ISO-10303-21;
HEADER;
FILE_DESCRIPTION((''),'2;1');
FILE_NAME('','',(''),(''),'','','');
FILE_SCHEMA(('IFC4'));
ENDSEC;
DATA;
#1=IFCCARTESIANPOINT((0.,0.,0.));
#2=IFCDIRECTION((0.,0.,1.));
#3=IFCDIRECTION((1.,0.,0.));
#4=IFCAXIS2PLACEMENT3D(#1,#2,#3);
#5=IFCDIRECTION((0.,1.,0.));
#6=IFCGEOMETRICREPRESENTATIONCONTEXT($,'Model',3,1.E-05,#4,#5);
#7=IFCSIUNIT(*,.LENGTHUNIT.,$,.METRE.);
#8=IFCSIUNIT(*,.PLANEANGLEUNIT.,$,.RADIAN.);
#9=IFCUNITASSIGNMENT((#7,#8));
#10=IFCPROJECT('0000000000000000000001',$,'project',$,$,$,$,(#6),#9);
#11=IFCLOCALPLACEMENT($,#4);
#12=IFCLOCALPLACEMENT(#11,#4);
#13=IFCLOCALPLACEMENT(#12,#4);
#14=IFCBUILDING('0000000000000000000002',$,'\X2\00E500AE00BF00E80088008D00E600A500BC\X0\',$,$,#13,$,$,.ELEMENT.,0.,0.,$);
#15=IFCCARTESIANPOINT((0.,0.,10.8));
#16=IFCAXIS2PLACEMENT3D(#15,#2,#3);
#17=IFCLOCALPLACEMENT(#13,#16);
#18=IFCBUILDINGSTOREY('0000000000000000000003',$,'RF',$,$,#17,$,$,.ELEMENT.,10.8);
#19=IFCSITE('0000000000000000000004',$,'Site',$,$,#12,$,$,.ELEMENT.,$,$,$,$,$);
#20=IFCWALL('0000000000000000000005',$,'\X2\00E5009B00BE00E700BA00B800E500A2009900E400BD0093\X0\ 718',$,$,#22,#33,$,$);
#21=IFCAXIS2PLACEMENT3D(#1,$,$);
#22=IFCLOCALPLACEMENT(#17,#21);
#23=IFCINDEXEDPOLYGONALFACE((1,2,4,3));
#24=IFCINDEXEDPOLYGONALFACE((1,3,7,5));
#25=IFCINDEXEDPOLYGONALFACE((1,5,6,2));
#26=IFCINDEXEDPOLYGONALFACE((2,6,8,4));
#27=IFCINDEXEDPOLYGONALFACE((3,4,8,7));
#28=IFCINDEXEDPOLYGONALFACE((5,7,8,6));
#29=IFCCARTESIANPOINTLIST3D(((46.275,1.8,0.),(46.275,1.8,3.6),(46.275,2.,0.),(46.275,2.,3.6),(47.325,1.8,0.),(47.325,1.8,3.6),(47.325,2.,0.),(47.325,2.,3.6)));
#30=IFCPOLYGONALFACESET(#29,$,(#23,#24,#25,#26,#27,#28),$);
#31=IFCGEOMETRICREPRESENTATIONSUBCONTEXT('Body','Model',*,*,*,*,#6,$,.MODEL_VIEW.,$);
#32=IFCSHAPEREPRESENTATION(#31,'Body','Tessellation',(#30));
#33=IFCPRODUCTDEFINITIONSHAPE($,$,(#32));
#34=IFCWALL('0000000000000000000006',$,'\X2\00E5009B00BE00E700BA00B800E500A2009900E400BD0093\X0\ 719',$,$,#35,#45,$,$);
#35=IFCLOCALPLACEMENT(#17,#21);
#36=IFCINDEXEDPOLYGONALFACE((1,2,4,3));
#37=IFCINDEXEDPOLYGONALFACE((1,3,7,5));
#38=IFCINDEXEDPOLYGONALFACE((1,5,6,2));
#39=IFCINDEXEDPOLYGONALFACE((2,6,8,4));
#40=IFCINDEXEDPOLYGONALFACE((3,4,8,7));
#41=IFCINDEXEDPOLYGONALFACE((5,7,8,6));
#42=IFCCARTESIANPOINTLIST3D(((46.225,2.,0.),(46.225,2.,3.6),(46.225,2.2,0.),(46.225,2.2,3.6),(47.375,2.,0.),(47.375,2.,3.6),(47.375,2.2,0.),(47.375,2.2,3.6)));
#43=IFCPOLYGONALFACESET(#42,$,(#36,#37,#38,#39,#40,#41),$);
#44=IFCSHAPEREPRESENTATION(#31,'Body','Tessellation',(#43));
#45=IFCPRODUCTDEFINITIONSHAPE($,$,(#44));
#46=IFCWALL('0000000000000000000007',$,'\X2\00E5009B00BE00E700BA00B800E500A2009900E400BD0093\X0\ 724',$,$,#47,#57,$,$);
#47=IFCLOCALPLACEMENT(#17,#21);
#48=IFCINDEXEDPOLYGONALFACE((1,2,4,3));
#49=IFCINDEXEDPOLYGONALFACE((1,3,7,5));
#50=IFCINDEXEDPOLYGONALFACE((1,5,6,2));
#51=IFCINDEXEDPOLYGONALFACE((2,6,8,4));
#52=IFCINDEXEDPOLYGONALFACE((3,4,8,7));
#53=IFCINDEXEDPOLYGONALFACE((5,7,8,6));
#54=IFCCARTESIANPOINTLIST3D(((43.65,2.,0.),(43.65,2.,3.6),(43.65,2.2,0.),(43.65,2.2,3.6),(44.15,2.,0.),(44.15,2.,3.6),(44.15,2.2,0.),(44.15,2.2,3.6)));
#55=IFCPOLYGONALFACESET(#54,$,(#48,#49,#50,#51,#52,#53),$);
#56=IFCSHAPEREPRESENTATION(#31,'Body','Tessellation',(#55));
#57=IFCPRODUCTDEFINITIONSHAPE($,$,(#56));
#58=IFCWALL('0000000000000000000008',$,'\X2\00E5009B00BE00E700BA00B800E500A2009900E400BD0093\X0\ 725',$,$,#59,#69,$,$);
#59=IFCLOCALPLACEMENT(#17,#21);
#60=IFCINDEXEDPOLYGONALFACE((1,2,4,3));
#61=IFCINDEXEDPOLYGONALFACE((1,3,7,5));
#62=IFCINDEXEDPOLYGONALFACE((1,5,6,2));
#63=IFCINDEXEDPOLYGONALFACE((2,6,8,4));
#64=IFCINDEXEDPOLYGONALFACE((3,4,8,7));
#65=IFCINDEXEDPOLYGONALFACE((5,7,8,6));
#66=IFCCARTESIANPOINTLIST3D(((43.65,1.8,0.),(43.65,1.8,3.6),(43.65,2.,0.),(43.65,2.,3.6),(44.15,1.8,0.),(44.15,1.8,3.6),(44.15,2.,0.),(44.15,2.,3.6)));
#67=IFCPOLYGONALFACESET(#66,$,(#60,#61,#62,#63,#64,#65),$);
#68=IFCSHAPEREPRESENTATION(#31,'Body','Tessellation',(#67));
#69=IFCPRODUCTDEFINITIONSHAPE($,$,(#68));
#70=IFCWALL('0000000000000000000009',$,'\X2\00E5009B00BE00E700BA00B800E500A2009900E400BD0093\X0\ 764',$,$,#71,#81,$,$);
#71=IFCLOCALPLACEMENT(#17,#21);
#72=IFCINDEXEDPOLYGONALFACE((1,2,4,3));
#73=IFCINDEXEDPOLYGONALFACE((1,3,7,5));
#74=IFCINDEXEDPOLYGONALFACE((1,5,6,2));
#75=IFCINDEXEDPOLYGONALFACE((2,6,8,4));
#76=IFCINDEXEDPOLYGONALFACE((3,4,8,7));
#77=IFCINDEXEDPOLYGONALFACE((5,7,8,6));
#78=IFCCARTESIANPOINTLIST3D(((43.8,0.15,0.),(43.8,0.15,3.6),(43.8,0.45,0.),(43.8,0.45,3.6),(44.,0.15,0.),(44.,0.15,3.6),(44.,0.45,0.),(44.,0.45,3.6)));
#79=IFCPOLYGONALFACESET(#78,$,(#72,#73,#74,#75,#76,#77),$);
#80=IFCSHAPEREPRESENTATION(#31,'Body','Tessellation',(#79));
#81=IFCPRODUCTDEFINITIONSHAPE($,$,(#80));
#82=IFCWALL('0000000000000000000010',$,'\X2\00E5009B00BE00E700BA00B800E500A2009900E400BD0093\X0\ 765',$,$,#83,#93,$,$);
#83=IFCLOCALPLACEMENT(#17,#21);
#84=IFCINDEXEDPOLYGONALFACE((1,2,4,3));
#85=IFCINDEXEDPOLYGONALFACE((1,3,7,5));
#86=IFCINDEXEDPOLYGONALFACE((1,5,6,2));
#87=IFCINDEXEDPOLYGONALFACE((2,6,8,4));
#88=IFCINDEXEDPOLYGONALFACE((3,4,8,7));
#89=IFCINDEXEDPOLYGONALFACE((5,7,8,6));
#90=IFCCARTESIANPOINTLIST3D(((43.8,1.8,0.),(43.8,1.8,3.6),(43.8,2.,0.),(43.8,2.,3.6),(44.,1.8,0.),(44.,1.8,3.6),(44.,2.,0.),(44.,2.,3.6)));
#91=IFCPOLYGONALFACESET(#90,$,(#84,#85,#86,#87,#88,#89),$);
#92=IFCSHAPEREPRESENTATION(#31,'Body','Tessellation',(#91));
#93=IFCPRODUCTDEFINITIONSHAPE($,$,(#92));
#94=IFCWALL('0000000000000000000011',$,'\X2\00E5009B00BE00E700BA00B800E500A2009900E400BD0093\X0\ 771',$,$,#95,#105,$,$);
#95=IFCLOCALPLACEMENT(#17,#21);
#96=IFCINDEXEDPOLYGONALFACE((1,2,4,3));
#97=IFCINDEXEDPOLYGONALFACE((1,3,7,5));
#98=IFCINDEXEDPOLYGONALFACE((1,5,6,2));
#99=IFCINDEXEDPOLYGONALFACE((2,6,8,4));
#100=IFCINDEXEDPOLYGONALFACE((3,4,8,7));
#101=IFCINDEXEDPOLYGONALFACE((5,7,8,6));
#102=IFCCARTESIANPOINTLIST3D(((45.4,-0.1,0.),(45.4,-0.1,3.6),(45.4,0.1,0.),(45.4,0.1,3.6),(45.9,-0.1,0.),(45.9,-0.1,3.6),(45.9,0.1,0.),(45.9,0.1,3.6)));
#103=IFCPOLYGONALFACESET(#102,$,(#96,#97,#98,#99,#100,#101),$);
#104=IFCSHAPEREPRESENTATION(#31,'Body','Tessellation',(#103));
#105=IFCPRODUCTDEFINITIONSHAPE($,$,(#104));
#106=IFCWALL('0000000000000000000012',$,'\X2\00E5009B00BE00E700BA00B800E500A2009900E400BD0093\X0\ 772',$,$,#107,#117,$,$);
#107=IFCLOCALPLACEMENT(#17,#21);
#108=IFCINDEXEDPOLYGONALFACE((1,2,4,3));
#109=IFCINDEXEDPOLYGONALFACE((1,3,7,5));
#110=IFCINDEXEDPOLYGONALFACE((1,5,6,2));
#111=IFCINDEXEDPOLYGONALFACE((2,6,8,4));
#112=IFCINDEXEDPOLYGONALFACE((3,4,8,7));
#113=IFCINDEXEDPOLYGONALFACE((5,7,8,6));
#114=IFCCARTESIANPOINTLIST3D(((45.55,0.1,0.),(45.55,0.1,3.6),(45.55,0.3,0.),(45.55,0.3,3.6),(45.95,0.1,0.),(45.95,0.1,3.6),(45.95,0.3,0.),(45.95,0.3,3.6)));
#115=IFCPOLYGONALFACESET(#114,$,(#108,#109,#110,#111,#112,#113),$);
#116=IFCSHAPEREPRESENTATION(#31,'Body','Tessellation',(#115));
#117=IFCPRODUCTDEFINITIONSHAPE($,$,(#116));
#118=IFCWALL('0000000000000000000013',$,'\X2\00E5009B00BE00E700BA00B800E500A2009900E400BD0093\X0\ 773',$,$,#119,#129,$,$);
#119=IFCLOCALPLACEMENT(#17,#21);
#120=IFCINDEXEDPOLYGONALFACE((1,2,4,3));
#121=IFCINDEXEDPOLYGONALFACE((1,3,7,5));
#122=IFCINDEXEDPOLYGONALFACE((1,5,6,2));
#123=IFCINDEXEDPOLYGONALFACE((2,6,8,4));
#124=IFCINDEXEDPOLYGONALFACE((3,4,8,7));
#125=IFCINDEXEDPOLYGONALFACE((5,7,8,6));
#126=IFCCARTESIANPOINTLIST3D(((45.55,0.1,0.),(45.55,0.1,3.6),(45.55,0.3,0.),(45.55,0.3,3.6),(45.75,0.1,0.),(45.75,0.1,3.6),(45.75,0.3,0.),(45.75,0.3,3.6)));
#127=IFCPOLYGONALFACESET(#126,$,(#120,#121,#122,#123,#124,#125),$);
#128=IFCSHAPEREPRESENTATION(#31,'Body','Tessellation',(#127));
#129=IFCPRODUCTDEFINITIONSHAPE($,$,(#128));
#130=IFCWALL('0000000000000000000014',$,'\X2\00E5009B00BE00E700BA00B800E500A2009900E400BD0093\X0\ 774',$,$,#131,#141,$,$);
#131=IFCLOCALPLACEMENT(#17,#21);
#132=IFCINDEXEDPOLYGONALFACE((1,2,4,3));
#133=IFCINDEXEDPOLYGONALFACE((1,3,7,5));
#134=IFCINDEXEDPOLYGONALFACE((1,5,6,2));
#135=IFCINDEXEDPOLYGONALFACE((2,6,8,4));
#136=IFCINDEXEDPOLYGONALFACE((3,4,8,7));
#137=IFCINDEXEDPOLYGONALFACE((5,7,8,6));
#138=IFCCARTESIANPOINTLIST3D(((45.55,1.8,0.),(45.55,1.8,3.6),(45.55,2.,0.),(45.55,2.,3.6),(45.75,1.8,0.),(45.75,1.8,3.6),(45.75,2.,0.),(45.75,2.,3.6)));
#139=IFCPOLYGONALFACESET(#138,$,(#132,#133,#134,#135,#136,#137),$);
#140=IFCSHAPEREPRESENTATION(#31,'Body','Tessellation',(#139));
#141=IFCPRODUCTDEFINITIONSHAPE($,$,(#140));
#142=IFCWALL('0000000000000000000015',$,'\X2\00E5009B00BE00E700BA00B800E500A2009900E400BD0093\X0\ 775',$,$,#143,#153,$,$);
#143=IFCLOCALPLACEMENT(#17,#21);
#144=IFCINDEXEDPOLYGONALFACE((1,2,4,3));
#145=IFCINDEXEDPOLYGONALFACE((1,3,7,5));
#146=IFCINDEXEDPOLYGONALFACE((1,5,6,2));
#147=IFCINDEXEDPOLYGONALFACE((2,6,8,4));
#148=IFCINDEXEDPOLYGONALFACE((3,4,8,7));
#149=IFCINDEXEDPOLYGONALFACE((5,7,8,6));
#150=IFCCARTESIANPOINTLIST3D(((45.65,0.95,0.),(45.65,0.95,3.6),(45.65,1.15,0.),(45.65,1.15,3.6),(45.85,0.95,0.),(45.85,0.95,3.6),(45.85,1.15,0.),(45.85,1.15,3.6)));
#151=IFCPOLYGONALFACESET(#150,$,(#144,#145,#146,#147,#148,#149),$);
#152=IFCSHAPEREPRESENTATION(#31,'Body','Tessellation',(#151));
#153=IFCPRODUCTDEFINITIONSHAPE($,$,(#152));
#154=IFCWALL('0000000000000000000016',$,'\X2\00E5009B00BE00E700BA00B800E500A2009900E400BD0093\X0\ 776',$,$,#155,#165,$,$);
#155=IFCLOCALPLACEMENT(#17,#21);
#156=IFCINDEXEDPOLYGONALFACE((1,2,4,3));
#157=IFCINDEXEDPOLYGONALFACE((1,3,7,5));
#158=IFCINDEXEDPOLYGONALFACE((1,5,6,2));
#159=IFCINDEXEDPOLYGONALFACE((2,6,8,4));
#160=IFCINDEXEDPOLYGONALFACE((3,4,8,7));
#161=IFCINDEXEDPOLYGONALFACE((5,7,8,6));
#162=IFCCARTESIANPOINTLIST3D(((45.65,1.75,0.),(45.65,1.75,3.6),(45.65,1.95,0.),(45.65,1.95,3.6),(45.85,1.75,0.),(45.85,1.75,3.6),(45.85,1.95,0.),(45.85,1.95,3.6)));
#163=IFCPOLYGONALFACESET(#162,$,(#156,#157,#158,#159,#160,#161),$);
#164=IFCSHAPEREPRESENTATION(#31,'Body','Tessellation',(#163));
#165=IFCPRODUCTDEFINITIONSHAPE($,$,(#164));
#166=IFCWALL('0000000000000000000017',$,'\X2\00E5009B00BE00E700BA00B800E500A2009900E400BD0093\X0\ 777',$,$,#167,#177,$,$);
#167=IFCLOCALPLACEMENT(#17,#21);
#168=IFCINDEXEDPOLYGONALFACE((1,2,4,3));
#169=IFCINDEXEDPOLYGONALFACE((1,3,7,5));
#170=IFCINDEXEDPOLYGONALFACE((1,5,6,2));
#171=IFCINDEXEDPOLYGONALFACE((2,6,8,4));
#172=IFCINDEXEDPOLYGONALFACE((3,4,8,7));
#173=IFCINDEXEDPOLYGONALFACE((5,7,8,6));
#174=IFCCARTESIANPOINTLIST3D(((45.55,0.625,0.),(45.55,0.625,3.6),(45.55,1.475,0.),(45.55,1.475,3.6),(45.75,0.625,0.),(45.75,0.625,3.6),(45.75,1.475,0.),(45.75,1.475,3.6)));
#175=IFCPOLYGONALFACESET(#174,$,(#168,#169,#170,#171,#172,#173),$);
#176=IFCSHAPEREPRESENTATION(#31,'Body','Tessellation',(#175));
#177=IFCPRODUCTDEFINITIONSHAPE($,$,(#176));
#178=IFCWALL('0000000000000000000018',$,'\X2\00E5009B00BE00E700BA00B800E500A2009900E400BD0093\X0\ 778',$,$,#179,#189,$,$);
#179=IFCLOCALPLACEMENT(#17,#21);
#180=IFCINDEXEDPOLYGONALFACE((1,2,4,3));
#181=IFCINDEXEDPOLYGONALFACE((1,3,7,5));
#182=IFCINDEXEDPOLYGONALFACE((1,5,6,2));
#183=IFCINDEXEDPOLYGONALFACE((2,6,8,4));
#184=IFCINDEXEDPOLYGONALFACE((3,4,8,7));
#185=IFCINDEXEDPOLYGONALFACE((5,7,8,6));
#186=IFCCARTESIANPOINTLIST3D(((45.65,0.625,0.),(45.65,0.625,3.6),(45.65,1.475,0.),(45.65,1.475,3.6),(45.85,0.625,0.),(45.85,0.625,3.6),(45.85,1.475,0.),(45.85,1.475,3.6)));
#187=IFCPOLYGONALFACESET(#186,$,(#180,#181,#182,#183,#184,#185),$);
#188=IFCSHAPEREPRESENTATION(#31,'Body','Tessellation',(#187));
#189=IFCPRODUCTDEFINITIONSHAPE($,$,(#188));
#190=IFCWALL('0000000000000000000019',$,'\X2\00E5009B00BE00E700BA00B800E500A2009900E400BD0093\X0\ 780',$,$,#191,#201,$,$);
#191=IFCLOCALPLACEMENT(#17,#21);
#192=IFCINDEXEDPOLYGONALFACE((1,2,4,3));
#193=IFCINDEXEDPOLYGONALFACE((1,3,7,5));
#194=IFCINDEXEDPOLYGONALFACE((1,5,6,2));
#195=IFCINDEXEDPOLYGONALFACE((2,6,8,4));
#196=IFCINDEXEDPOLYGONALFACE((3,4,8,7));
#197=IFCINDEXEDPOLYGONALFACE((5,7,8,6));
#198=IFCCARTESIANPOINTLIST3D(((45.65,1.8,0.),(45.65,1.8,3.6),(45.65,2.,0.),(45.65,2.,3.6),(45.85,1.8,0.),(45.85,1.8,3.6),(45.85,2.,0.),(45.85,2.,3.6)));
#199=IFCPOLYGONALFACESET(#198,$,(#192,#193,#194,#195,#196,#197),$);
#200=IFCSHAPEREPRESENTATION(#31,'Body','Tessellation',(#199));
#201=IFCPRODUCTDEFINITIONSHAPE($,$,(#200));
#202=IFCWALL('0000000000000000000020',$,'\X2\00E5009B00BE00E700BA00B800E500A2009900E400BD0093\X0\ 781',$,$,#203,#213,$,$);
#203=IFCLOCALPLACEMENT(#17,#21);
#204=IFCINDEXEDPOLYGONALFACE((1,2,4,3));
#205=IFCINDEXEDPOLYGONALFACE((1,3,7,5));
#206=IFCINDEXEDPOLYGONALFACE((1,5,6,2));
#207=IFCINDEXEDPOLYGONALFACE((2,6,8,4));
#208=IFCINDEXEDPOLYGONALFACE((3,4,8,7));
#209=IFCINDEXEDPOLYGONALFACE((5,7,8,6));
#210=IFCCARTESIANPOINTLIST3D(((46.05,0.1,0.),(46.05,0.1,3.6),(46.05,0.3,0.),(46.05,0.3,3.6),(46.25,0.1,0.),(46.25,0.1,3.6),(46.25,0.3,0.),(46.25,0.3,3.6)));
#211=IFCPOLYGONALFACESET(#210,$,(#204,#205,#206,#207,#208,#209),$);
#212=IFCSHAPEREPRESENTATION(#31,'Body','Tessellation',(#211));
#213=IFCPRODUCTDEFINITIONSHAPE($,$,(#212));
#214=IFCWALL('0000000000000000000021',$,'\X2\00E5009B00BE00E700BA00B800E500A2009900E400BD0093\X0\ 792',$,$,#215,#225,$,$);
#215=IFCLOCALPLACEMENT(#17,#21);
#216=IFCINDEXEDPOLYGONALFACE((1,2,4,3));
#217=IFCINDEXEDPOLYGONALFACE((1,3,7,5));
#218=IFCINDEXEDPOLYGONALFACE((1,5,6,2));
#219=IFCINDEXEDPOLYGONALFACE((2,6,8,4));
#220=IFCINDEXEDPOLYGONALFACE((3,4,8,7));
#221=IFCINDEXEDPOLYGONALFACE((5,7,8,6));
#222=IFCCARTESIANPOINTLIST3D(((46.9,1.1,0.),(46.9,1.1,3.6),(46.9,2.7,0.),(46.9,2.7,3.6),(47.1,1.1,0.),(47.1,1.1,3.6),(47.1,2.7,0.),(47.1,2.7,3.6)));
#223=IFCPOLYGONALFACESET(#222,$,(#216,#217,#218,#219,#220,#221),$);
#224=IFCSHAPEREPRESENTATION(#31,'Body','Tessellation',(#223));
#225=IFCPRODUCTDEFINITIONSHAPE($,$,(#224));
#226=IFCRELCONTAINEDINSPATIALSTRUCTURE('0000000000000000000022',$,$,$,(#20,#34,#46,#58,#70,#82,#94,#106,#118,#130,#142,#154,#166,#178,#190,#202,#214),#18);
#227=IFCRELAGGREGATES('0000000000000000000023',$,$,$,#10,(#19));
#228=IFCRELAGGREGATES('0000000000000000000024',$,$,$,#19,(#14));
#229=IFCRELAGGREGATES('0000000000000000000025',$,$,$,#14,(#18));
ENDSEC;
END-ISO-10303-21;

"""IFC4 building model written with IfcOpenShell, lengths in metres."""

from ifc_helpers import new_model, si_unit, direction, frame, frame_2d, origin_with_axes, place, context, subcontext, project, spatial, rectangle, extrude, element, save


model = new_model("IFC4")

# Units and contexts
model_context = context("Model", 3, precision=1e-05, world=origin_with_axes(), true_north=direction((0.0, 1.0, 0.0)))
body_context = subcontext(model_context, "Body", "Model", "MODEL_VIEW")
ifc_project = project(units=[si_unit("LENGTHUNIT", "METRE"), si_unit("PLANEANGLEUNIT", "RADIAN")], contexts=[model_context])

# Site, building, storey
placement = place(None, origin_with_axes())
site_placement = place(placement, origin_with_axes())
site = spatial("IfcSite", under=ifc_project, at=site_placement, Name="Site", CompositionType="ELEMENT")
building_placement = place(site_placement, origin_with_axes())
building = spatial("IfcBuilding", under=site, at=building_placement, Name="å®¿è\u0088\u008dæ¥¼", CompositionType="ELEMENT", ElevationOfRefHeight=0.0, ElevationOfTerrain=0.0)
storey_placement = place(building_placement, frame((0.0, 0.0, 10.8), z_axis=(0.0, 0.0, 1.0), x_axis=(1.0, 0.0, 0.0)))
storey = spatial("IfcBuildingStorey", under=building, at=storey_placement, Name="RF", CompositionType="ELEMENT", Elevation=10.8)

# Walls
wall_1_placement = place(storey_placement, frame((46.8, 1.9, 0.0), z_axis=(0.0, 0.0, 1.0), x_axis=(-1.0, 0.0, 0.0)))
element("IfcWall", 1, at=wall_1_placement, inside=storey, Name="å\u009b¾çº¸å¢\u0099ä½\u0093 718", context=body_context, shape_type="SweptSolid", body=[
    extrude(rectangle(XDim=1.05, YDim=0.2, at=frame_2d((0.0, 0.0), x_axis=(1.0, 0.0, 0.0))), frame((0.0, 0.0, 0.0), z_axis=(0.0, 0.0, 1.0)), (0.0, 0.0, 1.0), 3.6),
])
wall_2_placement = place(storey_placement, frame((46.8, 2.1, 0.0), z_axis=(0.0, 0.0, 1.0), x_axis=(-1.0, 0.0, 0.0)))
element("IfcWall", 2, at=wall_2_placement, inside=storey, Name="å\u009b¾çº¸å¢\u0099ä½\u0093 719", context=body_context, shape_type="SweptSolid", body=[
    extrude(rectangle(XDim=1.15, YDim=0.2, at=frame_2d((0.0, 0.0), x_axis=(1.0, 0.0, 0.0))), frame((0.0, 0.0, 0.0), z_axis=(0.0, 0.0, 1.0)), (0.0, 0.0, 1.0), 3.6),
])
for number, where, z_axis, x_axis, name in (
    (3, (43.9, 2.1, 0.0), (0.0, 0.0, 1.0), (-1.0, 0.0, 0.0), "å\u009b¾çº¸å¢\u0099ä½\u0093 724"),
    (4, (43.9, 1.9, 0.0), (0.0, 0.0, 1.0), (-1.0, 0.0, 0.0), "å\u009b¾çº¸å¢\u0099ä½\u0093 725"),
):
    element("IfcWall", number, at=place(storey_placement, frame(where, z_axis=z_axis, x_axis=x_axis)), inside=storey, Name=name, context=body_context, shape_type="SweptSolid", body=[
        extrude(rectangle(XDim=0.5, YDim=0.2, at=frame_2d((0.0, 0.0), x_axis=(1.0, 0.0, 0.0))), frame((0.0, 0.0, 0.0), z_axis=(0.0, 0.0, 1.0)), (0.0, 0.0, 1.0), 3.6),
    ])
wall_3_placement = place(storey_placement, frame((43.9, 0.3, 0.0), z_axis=(0.0, 0.0, 1.0), x_axis=(0.0, -1.0, 0.0)))
element("IfcWall", 5, at=wall_3_placement, inside=storey, Name="å\u009b¾çº¸å¢\u0099ä½\u0093 764", context=body_context, shape_type="SweptSolid", body=[
    extrude(rectangle(XDim=0.3, YDim=0.2, at=frame_2d((0.0, 0.0), x_axis=(1.0, 0.0, 0.0))), frame((0.0, 0.0, 0.0), z_axis=(0.0, 0.0, 1.0)), (0.0, 0.0, 1.0), 3.6),
])
wall_4_placement = place(storey_placement, frame((43.9, 1.9, 0.0), z_axis=(0.0, 0.0, 1.0), x_axis=(0.0, 1.0, 0.0)))
element("IfcWall", 6, at=wall_4_placement, inside=storey, Name="å\u009b¾çº¸å¢\u0099ä½\u0093 765", context=body_context, shape_type="SweptSolid", body=[
    extrude(rectangle(XDim=0.2, YDim=0.2, at=frame_2d((0.0, 0.0), x_axis=(1.0, 0.0, 0.0))), frame((0.0, 0.0, 0.0), z_axis=(0.0, 0.0, 1.0)), (0.0, 0.0, 1.0), 3.6),
])
wall_5_placement = place(storey_placement, frame((45.65, 0.0, 0.0), z_axis=(0.0, 0.0, 1.0), x_axis=(1.0, 0.0, 0.0)))
element("IfcWall", 7, at=wall_5_placement, inside=storey, Name="å\u009b¾çº¸å¢\u0099ä½\u0093 771", context=body_context, shape_type="SweptSolid", body=[
    extrude(rectangle(XDim=0.5, YDim=0.2, at=frame_2d((0.0, 0.0), x_axis=(1.0, 0.0, 0.0))), frame((0.0, 0.0, 0.0), z_axis=(0.0, 0.0, 1.0)), (0.0, 0.0, 1.0), 3.6),
])
wall_6_placement = place(storey_placement, frame((45.75, 0.2, 0.0), z_axis=(0.0, 0.0, 1.0), x_axis=(1.0, 0.0, 0.0)))
element("IfcWall", 8, at=wall_6_placement, inside=storey, Name="å\u009b¾çº¸å¢\u0099ä½\u0093 772", context=body_context, shape_type="SweptSolid", body=[
    extrude(rectangle(XDim=0.4, YDim=0.2, at=frame_2d((0.0, 0.0), x_axis=(1.0, 0.0, 0.0))), frame((0.0, 0.0, 0.0), z_axis=(0.0, 0.0, 1.0)), (0.0, 0.0, 1.0), 3.6),
])
for number, where, z_axis, x_axis, name in (
    (9, (45.65, 0.2, 0.0), (0.0, 0.0, 1.0), (0.0, -1.0, 0.0), "å\u009b¾çº¸å¢\u0099ä½\u0093 773"),
    (10, (45.65, 1.9, 0.0), (0.0, 0.0, 1.0), (0.0, 1.0, 0.0), "å\u009b¾çº¸å¢\u0099ä½\u0093 774"),
    (11, (45.75, 1.05, 0.0), (0.0, 0.0, 1.0), (-1.0, 0.0, 0.0), "å\u009b¾çº¸å¢\u0099ä½\u0093 775"),
    (12, (45.75, 1.85, 0.0), (0.0, 0.0, 1.0), (-1.0, 0.0, 0.0), "å\u009b¾çº¸å¢\u0099ä½\u0093 776"),
):
    element("IfcWall", number, at=place(storey_placement, frame(where, z_axis=z_axis, x_axis=x_axis)), inside=storey, Name=name, context=body_context, shape_type="SweptSolid", body=[
        extrude(rectangle(XDim=0.2, YDim=0.2, at=frame_2d((0.0, 0.0), x_axis=(1.0, 0.0, 0.0))), frame((0.0, 0.0, 0.0), z_axis=(0.0, 0.0, 1.0)), (0.0, 0.0, 1.0), 3.6),
    ])
for number, where, z_axis, x_axis, name in (
    (13, (45.65, 1.05, 0.0), (0.0, 0.0, 1.0), (0.0, -1.0, 0.0), "å\u009b¾çº¸å¢\u0099ä½\u0093 777"),
    (14, (45.75, 1.05, 0.0), (0.0, 0.0, 1.0), (0.0, -1.0, 0.0), "å\u009b¾çº¸å¢\u0099ä½\u0093 778"),
):
    element("IfcWall", number, at=place(storey_placement, frame(where, z_axis=z_axis, x_axis=x_axis)), inside=storey, Name=name, context=body_context, shape_type="SweptSolid", body=[
        extrude(rectangle(XDim=0.85, YDim=0.2, at=frame_2d((0.0, 0.0), x_axis=(1.0, 0.0, 0.0))), frame((0.0, 0.0, 0.0), z_axis=(0.0, 0.0, 1.0)), (0.0, 0.0, 1.0), 3.6),
    ])
for number, where, z_axis, x_axis, name in (
    (15, (45.75, 1.9, 0.0), (0.0, 0.0, 1.0), (0.0, -1.0, 0.0), "å\u009b¾çº¸å¢\u0099ä½\u0093 780"),
    (16, (46.15, 0.2, 0.0), (0.0, 0.0, 1.0), (0.0, -1.0, 0.0), "å\u009b¾çº¸å¢\u0099ä½\u0093 781"),
):
    element("IfcWall", number, at=place(storey_placement, frame(where, z_axis=z_axis, x_axis=x_axis)), inside=storey, Name=name, context=body_context, shape_type="SweptSolid", body=[
        extrude(rectangle(XDim=0.2, YDim=0.2, at=frame_2d((0.0, 0.0), x_axis=(1.0, 0.0, 0.0))), frame((0.0, 0.0, 0.0), z_axis=(0.0, 0.0, 1.0)), (0.0, 0.0, 1.0), 3.6),
    ])
for number, where, z_axis, x_axis, name in (
    (17, (47.0, 1.9, 0.0), (0.0, 0.0, 1.0), (0.0, -1.0, 0.0), "å\u009b¾çº¸å¢\u0099ä½\u0093 792"),
):
    element("IfcWall", number, at=place(storey_placement, frame(where, z_axis=z_axis, x_axis=x_axis)), inside=storey, Name=name, context=body_context, shape_type="SweptSolid", body=[
        extrude(rectangle(XDim=1.6, YDim=0.2, at=frame_2d((0.0, 0.0), x_axis=(1.0, 0.0, 0.0))), frame((0.0, 0.0, 0.0), z_axis=(0.0, 0.0, 1.0)), (0.0, 0.0, 1.0), 3.6),
    ])

save(model, "model.ifc")
